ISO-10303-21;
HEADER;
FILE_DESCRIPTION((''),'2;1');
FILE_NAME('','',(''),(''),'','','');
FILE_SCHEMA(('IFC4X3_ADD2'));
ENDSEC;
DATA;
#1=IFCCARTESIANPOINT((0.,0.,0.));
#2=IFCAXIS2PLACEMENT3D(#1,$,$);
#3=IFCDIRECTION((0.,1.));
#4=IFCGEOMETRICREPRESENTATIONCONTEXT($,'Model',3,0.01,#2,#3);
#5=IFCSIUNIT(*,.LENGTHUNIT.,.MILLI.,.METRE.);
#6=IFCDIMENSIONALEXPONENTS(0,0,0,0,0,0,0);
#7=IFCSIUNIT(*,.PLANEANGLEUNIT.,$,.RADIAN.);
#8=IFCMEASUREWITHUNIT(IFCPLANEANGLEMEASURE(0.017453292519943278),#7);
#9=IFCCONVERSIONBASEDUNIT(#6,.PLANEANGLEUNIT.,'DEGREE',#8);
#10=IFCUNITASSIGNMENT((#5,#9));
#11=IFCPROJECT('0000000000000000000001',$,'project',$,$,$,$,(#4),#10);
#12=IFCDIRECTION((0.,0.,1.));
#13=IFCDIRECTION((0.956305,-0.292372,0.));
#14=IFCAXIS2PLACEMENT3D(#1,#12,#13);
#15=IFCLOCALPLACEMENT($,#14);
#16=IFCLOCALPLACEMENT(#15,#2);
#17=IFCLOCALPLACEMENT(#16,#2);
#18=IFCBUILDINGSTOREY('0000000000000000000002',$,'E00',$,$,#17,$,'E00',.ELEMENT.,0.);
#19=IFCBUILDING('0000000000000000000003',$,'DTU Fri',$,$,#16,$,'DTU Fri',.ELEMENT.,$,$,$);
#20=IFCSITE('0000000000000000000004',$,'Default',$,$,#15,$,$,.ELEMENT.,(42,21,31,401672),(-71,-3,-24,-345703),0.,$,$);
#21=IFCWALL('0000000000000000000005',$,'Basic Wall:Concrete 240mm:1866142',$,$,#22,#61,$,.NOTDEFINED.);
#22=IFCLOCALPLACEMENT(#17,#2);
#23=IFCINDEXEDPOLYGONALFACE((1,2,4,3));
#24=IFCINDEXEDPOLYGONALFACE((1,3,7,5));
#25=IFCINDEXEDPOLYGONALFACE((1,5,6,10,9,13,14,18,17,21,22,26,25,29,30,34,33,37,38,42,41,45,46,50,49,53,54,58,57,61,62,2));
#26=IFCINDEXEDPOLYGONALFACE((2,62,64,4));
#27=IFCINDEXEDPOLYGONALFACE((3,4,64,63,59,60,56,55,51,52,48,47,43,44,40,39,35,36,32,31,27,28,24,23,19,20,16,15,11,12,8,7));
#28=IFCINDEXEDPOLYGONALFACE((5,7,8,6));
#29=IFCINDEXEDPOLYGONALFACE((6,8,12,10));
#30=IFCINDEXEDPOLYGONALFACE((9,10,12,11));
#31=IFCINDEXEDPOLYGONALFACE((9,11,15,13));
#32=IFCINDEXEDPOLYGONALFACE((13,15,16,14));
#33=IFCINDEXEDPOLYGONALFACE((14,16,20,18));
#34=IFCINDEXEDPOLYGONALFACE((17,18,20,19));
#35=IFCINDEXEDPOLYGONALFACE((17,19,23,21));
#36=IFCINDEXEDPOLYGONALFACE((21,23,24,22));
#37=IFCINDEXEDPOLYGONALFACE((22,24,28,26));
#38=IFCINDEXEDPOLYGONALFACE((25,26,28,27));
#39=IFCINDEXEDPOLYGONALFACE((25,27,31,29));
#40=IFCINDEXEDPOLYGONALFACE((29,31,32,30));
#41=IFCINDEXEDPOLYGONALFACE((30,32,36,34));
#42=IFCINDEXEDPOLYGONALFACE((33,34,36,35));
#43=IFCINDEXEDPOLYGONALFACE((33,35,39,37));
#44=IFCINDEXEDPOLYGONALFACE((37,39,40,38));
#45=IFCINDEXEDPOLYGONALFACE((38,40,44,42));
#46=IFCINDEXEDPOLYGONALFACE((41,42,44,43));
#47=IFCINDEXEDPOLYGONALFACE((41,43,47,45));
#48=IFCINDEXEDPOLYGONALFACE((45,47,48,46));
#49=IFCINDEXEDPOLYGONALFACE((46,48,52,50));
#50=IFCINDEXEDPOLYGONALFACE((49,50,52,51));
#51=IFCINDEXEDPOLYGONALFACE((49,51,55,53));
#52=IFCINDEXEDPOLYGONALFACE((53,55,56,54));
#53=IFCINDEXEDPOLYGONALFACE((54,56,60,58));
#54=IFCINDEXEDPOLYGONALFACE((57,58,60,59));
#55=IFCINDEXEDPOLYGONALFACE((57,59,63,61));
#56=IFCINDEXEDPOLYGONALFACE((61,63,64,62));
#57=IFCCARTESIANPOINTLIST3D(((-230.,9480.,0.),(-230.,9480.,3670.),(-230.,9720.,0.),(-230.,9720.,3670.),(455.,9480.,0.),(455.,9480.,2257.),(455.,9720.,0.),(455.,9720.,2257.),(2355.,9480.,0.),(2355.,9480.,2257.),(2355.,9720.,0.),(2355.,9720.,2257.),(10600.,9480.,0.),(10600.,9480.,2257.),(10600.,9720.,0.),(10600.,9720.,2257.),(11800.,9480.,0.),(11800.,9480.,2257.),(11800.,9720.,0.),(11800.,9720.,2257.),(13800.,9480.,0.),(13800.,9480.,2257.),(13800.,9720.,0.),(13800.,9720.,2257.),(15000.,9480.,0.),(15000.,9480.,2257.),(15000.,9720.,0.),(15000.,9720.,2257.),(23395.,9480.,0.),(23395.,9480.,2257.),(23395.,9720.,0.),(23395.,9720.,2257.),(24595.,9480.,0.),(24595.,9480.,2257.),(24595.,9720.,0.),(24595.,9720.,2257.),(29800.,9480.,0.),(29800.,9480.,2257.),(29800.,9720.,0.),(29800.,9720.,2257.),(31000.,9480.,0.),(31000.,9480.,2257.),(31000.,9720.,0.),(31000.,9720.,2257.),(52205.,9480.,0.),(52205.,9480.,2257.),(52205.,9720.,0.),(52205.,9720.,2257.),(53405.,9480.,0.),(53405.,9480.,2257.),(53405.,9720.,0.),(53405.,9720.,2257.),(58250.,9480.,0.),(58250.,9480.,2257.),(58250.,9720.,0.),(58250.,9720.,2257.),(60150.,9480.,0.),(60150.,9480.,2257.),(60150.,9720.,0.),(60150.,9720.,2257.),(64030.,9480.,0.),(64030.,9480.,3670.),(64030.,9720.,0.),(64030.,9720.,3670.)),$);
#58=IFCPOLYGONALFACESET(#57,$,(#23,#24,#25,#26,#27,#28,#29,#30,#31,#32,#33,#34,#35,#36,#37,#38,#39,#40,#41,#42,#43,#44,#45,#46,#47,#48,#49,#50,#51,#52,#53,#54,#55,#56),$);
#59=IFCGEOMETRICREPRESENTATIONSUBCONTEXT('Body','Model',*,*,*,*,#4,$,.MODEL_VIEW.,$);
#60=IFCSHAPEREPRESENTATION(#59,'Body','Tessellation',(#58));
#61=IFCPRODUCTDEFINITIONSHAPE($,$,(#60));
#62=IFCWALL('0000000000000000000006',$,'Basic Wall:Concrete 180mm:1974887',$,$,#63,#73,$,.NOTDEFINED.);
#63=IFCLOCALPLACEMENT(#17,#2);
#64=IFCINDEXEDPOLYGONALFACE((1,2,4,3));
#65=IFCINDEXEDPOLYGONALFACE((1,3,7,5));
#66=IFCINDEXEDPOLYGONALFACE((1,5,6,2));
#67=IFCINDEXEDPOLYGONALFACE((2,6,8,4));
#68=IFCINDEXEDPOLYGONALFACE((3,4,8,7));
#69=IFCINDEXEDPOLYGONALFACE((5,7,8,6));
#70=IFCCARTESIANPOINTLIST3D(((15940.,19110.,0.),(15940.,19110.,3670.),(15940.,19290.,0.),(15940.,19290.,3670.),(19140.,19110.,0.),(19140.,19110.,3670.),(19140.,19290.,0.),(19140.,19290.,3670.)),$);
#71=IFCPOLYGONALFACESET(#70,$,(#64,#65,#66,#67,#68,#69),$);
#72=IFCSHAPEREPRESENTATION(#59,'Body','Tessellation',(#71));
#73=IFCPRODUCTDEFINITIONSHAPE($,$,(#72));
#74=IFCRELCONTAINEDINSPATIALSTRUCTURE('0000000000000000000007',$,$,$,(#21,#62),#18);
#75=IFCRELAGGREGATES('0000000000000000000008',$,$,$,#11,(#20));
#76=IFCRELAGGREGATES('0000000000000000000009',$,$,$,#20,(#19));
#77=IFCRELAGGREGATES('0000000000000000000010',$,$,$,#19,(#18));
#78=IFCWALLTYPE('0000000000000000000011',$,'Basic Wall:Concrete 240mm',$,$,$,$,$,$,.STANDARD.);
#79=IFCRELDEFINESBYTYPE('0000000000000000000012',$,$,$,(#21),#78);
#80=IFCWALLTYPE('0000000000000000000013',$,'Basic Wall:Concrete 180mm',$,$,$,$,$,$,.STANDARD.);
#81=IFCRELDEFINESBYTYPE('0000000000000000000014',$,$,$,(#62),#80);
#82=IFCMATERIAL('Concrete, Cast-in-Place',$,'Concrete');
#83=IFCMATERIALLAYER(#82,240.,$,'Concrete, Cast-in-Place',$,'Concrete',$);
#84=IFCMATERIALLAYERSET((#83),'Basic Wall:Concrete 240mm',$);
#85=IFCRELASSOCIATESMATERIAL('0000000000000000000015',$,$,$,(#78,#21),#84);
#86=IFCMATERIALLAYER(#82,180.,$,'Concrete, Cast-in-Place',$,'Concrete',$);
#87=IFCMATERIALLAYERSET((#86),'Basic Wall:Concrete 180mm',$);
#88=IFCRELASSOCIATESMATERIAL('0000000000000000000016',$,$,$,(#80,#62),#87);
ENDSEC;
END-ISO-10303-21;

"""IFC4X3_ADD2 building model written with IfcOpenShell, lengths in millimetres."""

from ifc_helpers import new_model, entity, si_unit, converted_unit, direction, frame, frame_2d, origin, place, context, subcontext, project, spatial, rectangle, extrude, material, layer, layer_set, type_object, element, save


model = new_model("IFC4X3_ADD2")

# Units and contexts
model_context = context("Model", 3, precision=0.01, world=origin(), true_north=direction((0.0, 1.0)))
body_context = subcontext(model_context, "Body", "Model", "MODEL_VIEW")
ifc_project = project(units=[si_unit("LENGTHUNIT", "METRE", prefix="MILLI"), converted_unit("PLANEANGLEUNIT", "DEGREE", entity("IfcPlaneAngleMeasure", 0.017453292519943278), si_unit("PLANEANGLEUNIT", "RADIAN"), dimensions=[0, 0, 0, 0, 0, 0, 0])], contexts=[model_context])

# Site, building, storey
site_placement = place(None, frame((0.0, 0.0, 0.0), z_axis=(0.0, 0.0, 1.0), x_axis=(0.956305, -0.292372, 0.0)))
site = spatial("IfcSite", under=ifc_project, at=site_placement, Name="Default", CompositionType="ELEMENT", RefLatitude=(42, 21, 31, 401672), RefLongitude=(-71, -3, -24, -345703), RefElevation=0.0)
building_placement = place(site_placement, origin())
building = spatial("IfcBuilding", under=site, at=building_placement, Name="DTU Fri", LongName="DTU Fri", CompositionType="ELEMENT")
storey_placement = place(building_placement, origin())
storey = spatial("IfcBuildingStorey", under=building, at=storey_placement, Name="E00", LongName="E00", CompositionType="ELEMENT", Elevation=0.0)

# Shared definitions
ifc_material_1 = material(Name="Concrete, Cast-in-Place", Category="Concrete")

# Wall, openings
ifc_layer_1 = layer(ifc_material_1, 240.0, Name="Concrete, Cast-in-Place", Category="Concrete")
ifc_layer_set_1 = layer_set([ifc_layer_1], Name="Basic Wall:Concrete 240mm")
wall_type_1 = type_object("IfcWallType", Name="Basic Wall:Concrete 240mm", PredefinedType="STANDARD", material=ifc_layer_set_1)
wall_1_placement = place(storey_placement, frame((-230.0, 9600.0, 0.0)))
wall_1 = element("IfcWall", 1, at=wall_1_placement, inside=storey, type_object=wall_type_1, material=ifc_layer_set_1, Name="Basic Wall:Concrete 240mm:1866142", PredefinedType="NOTDEFINED", context=body_context, shape_type="SweptSolid", body=[
    extrude(rectangle(XDim=64260.0, YDim=240.0, at=frame_2d((32130.0, 0.0), x_axis=(-1.0, 0.0))), origin(), (0.0, 0.0, 1.0), 3670.0),
])
opening_1_placement = place(wall_1_placement, origin())
element("IfcOpeningElement", 2, at=opening_1_placement, cuts=wall_1, PredefinedType="OPENING", context=body_context, shape_type="SweptSolid", body=[
    extrude(rectangle(XDim=2257.0, YDim=1900.0, at=frame_2d((0.0, 0.0), x_axis=(0.0, 1.0))), frame((1635.0, 120.0, 1128.5), z_axis=(0.0, -1.0, 0.0), x_axis=(1.0, 0.0, 0.0)), (0.0, 0.0, 1.0), 240.0),
])
opening_2_placement = place(wall_1_placement, origin())
element("IfcOpeningElement", 3, at=opening_2_placement, cuts=wall_1, PredefinedType="OPENING", context=body_context, shape_type="SweptSolid", body=[
    extrude(rectangle(XDim=2257.0, YDim=1200.0, at=frame_2d((0.0, 0.0), x_axis=(0.0, 1.0))), frame((11430.0, 120.0, 1128.5), z_axis=(0.0, -1.0, 0.0), x_axis=(1.0, 0.0, 0.0)), (0.0, 0.0, 1.0), 240.0),
])
opening_3_placement = place(wall_1_placement, origin())
element("IfcOpeningElement", 4, at=opening_3_placement, cuts=wall_1, PredefinedType="OPENING", context=body_context, shape_type="SweptSolid", body=[
    extrude(rectangle(XDim=2257.0, YDim=1200.0, at=frame_2d((0.0, 0.0), x_axis=(0.0, 1.0))), frame((14630.0, 120.0, 1128.5), z_axis=(0.0, -1.0, 0.0), x_axis=(1.0, 0.0, 0.0)), (0.0, 0.0, 1.0), 240.0),
])
opening_4_placement = place(wall_1_placement, origin())
element("IfcOpeningElement", 5, at=opening_4_placement, cuts=wall_1, PredefinedType="OPENING", context=body_context, shape_type="SweptSolid", body=[
    extrude(rectangle(XDim=2257.0, YDim=1200.0, at=frame_2d((0.0, 0.0), x_axis=(0.0, 1.0))), frame((24225.0, 120.0, 1128.5), z_axis=(0.0, -1.0, 0.0), x_axis=(1.0, 0.0, 0.0)), (0.0, 0.0, 1.0), 240.0),
])
opening_5_placement = place(wall_1_placement, origin())
element("IfcOpeningElement", 6, at=opening_5_placement, cuts=wall_1, PredefinedType="OPENING", context=body_context, shape_type="SweptSolid", body=[
    extrude(rectangle(XDim=2257.0, YDim=1200.0, at=frame_2d((0.0, 0.0), x_axis=(0.0, 1.0))), frame((30630.0, 120.0, 1128.5), z_axis=(0.0, -1.0, 0.0), x_axis=(1.0, 0.0, 0.0)), (0.0, 0.0, 1.0), 240.0),
])
opening_6_placement = place(wall_1_placement, origin())
element("IfcOpeningElement", 7, at=opening_6_placement, cuts=wall_1, PredefinedType="OPENING", context=body_context, shape_type="SweptSolid", body=[
    extrude(rectangle(XDim=2257.0, YDim=1200.0, at=frame_2d((0.0, 0.0), x_axis=(0.0, 1.0))), frame((53035.0, 120.0, 1128.5), z_axis=(0.0, -1.0, 0.0), x_axis=(1.0, 0.0, 0.0)), (0.0, 0.0, 1.0), 240.0),
])
opening_7_placement = place(wall_1_placement, origin())
element("IfcOpeningElement", 8, at=opening_7_placement, cuts=wall_1, PredefinedType="OPENING", context=body_context, shape_type="SweptSolid", body=[
    extrude(rectangle(XDim=2257.0, YDim=1900.0, at=frame_2d((0.0, 0.0), x_axis=(0.0, 1.0))), frame((59430.0, 120.0, 1128.5), z_axis=(0.0, -1.0, 0.0), x_axis=(1.0, 0.0, 0.0)), (0.0, 0.0, 1.0), 240.0),
])

# Wall
ifc_layer_2 = layer(ifc_material_1, 180.0, Name="Concrete, Cast-in-Place", Category="Concrete")
ifc_layer_set_2 = layer_set([ifc_layer_2], Name="Basic Wall:Concrete 180mm")
wall_type_2 = type_object("IfcWallType", Name="Basic Wall:Concrete 180mm", PredefinedType="STANDARD", material=ifc_layer_set_2)
wall_2_placement = place(storey_placement, frame((15940.0, 19200.0, 0.0)))
element("IfcWall", 9, at=wall_2_placement, inside=storey, type_object=wall_type_2, material=ifc_layer_set_2, Name="Basic Wall:Concrete 180mm:1974887", PredefinedType="NOTDEFINED", context=body_context, shape_type="SweptSolid", body=[
    extrude(rectangle(XDim=3200.0, YDim=180.0, at=frame_2d((1600.0, 0.0), x_axis=(-1.0, 0.0))), origin(), (0.0, 0.0, 1.0), 3670.0),
])

save(model, "model.ifc")
